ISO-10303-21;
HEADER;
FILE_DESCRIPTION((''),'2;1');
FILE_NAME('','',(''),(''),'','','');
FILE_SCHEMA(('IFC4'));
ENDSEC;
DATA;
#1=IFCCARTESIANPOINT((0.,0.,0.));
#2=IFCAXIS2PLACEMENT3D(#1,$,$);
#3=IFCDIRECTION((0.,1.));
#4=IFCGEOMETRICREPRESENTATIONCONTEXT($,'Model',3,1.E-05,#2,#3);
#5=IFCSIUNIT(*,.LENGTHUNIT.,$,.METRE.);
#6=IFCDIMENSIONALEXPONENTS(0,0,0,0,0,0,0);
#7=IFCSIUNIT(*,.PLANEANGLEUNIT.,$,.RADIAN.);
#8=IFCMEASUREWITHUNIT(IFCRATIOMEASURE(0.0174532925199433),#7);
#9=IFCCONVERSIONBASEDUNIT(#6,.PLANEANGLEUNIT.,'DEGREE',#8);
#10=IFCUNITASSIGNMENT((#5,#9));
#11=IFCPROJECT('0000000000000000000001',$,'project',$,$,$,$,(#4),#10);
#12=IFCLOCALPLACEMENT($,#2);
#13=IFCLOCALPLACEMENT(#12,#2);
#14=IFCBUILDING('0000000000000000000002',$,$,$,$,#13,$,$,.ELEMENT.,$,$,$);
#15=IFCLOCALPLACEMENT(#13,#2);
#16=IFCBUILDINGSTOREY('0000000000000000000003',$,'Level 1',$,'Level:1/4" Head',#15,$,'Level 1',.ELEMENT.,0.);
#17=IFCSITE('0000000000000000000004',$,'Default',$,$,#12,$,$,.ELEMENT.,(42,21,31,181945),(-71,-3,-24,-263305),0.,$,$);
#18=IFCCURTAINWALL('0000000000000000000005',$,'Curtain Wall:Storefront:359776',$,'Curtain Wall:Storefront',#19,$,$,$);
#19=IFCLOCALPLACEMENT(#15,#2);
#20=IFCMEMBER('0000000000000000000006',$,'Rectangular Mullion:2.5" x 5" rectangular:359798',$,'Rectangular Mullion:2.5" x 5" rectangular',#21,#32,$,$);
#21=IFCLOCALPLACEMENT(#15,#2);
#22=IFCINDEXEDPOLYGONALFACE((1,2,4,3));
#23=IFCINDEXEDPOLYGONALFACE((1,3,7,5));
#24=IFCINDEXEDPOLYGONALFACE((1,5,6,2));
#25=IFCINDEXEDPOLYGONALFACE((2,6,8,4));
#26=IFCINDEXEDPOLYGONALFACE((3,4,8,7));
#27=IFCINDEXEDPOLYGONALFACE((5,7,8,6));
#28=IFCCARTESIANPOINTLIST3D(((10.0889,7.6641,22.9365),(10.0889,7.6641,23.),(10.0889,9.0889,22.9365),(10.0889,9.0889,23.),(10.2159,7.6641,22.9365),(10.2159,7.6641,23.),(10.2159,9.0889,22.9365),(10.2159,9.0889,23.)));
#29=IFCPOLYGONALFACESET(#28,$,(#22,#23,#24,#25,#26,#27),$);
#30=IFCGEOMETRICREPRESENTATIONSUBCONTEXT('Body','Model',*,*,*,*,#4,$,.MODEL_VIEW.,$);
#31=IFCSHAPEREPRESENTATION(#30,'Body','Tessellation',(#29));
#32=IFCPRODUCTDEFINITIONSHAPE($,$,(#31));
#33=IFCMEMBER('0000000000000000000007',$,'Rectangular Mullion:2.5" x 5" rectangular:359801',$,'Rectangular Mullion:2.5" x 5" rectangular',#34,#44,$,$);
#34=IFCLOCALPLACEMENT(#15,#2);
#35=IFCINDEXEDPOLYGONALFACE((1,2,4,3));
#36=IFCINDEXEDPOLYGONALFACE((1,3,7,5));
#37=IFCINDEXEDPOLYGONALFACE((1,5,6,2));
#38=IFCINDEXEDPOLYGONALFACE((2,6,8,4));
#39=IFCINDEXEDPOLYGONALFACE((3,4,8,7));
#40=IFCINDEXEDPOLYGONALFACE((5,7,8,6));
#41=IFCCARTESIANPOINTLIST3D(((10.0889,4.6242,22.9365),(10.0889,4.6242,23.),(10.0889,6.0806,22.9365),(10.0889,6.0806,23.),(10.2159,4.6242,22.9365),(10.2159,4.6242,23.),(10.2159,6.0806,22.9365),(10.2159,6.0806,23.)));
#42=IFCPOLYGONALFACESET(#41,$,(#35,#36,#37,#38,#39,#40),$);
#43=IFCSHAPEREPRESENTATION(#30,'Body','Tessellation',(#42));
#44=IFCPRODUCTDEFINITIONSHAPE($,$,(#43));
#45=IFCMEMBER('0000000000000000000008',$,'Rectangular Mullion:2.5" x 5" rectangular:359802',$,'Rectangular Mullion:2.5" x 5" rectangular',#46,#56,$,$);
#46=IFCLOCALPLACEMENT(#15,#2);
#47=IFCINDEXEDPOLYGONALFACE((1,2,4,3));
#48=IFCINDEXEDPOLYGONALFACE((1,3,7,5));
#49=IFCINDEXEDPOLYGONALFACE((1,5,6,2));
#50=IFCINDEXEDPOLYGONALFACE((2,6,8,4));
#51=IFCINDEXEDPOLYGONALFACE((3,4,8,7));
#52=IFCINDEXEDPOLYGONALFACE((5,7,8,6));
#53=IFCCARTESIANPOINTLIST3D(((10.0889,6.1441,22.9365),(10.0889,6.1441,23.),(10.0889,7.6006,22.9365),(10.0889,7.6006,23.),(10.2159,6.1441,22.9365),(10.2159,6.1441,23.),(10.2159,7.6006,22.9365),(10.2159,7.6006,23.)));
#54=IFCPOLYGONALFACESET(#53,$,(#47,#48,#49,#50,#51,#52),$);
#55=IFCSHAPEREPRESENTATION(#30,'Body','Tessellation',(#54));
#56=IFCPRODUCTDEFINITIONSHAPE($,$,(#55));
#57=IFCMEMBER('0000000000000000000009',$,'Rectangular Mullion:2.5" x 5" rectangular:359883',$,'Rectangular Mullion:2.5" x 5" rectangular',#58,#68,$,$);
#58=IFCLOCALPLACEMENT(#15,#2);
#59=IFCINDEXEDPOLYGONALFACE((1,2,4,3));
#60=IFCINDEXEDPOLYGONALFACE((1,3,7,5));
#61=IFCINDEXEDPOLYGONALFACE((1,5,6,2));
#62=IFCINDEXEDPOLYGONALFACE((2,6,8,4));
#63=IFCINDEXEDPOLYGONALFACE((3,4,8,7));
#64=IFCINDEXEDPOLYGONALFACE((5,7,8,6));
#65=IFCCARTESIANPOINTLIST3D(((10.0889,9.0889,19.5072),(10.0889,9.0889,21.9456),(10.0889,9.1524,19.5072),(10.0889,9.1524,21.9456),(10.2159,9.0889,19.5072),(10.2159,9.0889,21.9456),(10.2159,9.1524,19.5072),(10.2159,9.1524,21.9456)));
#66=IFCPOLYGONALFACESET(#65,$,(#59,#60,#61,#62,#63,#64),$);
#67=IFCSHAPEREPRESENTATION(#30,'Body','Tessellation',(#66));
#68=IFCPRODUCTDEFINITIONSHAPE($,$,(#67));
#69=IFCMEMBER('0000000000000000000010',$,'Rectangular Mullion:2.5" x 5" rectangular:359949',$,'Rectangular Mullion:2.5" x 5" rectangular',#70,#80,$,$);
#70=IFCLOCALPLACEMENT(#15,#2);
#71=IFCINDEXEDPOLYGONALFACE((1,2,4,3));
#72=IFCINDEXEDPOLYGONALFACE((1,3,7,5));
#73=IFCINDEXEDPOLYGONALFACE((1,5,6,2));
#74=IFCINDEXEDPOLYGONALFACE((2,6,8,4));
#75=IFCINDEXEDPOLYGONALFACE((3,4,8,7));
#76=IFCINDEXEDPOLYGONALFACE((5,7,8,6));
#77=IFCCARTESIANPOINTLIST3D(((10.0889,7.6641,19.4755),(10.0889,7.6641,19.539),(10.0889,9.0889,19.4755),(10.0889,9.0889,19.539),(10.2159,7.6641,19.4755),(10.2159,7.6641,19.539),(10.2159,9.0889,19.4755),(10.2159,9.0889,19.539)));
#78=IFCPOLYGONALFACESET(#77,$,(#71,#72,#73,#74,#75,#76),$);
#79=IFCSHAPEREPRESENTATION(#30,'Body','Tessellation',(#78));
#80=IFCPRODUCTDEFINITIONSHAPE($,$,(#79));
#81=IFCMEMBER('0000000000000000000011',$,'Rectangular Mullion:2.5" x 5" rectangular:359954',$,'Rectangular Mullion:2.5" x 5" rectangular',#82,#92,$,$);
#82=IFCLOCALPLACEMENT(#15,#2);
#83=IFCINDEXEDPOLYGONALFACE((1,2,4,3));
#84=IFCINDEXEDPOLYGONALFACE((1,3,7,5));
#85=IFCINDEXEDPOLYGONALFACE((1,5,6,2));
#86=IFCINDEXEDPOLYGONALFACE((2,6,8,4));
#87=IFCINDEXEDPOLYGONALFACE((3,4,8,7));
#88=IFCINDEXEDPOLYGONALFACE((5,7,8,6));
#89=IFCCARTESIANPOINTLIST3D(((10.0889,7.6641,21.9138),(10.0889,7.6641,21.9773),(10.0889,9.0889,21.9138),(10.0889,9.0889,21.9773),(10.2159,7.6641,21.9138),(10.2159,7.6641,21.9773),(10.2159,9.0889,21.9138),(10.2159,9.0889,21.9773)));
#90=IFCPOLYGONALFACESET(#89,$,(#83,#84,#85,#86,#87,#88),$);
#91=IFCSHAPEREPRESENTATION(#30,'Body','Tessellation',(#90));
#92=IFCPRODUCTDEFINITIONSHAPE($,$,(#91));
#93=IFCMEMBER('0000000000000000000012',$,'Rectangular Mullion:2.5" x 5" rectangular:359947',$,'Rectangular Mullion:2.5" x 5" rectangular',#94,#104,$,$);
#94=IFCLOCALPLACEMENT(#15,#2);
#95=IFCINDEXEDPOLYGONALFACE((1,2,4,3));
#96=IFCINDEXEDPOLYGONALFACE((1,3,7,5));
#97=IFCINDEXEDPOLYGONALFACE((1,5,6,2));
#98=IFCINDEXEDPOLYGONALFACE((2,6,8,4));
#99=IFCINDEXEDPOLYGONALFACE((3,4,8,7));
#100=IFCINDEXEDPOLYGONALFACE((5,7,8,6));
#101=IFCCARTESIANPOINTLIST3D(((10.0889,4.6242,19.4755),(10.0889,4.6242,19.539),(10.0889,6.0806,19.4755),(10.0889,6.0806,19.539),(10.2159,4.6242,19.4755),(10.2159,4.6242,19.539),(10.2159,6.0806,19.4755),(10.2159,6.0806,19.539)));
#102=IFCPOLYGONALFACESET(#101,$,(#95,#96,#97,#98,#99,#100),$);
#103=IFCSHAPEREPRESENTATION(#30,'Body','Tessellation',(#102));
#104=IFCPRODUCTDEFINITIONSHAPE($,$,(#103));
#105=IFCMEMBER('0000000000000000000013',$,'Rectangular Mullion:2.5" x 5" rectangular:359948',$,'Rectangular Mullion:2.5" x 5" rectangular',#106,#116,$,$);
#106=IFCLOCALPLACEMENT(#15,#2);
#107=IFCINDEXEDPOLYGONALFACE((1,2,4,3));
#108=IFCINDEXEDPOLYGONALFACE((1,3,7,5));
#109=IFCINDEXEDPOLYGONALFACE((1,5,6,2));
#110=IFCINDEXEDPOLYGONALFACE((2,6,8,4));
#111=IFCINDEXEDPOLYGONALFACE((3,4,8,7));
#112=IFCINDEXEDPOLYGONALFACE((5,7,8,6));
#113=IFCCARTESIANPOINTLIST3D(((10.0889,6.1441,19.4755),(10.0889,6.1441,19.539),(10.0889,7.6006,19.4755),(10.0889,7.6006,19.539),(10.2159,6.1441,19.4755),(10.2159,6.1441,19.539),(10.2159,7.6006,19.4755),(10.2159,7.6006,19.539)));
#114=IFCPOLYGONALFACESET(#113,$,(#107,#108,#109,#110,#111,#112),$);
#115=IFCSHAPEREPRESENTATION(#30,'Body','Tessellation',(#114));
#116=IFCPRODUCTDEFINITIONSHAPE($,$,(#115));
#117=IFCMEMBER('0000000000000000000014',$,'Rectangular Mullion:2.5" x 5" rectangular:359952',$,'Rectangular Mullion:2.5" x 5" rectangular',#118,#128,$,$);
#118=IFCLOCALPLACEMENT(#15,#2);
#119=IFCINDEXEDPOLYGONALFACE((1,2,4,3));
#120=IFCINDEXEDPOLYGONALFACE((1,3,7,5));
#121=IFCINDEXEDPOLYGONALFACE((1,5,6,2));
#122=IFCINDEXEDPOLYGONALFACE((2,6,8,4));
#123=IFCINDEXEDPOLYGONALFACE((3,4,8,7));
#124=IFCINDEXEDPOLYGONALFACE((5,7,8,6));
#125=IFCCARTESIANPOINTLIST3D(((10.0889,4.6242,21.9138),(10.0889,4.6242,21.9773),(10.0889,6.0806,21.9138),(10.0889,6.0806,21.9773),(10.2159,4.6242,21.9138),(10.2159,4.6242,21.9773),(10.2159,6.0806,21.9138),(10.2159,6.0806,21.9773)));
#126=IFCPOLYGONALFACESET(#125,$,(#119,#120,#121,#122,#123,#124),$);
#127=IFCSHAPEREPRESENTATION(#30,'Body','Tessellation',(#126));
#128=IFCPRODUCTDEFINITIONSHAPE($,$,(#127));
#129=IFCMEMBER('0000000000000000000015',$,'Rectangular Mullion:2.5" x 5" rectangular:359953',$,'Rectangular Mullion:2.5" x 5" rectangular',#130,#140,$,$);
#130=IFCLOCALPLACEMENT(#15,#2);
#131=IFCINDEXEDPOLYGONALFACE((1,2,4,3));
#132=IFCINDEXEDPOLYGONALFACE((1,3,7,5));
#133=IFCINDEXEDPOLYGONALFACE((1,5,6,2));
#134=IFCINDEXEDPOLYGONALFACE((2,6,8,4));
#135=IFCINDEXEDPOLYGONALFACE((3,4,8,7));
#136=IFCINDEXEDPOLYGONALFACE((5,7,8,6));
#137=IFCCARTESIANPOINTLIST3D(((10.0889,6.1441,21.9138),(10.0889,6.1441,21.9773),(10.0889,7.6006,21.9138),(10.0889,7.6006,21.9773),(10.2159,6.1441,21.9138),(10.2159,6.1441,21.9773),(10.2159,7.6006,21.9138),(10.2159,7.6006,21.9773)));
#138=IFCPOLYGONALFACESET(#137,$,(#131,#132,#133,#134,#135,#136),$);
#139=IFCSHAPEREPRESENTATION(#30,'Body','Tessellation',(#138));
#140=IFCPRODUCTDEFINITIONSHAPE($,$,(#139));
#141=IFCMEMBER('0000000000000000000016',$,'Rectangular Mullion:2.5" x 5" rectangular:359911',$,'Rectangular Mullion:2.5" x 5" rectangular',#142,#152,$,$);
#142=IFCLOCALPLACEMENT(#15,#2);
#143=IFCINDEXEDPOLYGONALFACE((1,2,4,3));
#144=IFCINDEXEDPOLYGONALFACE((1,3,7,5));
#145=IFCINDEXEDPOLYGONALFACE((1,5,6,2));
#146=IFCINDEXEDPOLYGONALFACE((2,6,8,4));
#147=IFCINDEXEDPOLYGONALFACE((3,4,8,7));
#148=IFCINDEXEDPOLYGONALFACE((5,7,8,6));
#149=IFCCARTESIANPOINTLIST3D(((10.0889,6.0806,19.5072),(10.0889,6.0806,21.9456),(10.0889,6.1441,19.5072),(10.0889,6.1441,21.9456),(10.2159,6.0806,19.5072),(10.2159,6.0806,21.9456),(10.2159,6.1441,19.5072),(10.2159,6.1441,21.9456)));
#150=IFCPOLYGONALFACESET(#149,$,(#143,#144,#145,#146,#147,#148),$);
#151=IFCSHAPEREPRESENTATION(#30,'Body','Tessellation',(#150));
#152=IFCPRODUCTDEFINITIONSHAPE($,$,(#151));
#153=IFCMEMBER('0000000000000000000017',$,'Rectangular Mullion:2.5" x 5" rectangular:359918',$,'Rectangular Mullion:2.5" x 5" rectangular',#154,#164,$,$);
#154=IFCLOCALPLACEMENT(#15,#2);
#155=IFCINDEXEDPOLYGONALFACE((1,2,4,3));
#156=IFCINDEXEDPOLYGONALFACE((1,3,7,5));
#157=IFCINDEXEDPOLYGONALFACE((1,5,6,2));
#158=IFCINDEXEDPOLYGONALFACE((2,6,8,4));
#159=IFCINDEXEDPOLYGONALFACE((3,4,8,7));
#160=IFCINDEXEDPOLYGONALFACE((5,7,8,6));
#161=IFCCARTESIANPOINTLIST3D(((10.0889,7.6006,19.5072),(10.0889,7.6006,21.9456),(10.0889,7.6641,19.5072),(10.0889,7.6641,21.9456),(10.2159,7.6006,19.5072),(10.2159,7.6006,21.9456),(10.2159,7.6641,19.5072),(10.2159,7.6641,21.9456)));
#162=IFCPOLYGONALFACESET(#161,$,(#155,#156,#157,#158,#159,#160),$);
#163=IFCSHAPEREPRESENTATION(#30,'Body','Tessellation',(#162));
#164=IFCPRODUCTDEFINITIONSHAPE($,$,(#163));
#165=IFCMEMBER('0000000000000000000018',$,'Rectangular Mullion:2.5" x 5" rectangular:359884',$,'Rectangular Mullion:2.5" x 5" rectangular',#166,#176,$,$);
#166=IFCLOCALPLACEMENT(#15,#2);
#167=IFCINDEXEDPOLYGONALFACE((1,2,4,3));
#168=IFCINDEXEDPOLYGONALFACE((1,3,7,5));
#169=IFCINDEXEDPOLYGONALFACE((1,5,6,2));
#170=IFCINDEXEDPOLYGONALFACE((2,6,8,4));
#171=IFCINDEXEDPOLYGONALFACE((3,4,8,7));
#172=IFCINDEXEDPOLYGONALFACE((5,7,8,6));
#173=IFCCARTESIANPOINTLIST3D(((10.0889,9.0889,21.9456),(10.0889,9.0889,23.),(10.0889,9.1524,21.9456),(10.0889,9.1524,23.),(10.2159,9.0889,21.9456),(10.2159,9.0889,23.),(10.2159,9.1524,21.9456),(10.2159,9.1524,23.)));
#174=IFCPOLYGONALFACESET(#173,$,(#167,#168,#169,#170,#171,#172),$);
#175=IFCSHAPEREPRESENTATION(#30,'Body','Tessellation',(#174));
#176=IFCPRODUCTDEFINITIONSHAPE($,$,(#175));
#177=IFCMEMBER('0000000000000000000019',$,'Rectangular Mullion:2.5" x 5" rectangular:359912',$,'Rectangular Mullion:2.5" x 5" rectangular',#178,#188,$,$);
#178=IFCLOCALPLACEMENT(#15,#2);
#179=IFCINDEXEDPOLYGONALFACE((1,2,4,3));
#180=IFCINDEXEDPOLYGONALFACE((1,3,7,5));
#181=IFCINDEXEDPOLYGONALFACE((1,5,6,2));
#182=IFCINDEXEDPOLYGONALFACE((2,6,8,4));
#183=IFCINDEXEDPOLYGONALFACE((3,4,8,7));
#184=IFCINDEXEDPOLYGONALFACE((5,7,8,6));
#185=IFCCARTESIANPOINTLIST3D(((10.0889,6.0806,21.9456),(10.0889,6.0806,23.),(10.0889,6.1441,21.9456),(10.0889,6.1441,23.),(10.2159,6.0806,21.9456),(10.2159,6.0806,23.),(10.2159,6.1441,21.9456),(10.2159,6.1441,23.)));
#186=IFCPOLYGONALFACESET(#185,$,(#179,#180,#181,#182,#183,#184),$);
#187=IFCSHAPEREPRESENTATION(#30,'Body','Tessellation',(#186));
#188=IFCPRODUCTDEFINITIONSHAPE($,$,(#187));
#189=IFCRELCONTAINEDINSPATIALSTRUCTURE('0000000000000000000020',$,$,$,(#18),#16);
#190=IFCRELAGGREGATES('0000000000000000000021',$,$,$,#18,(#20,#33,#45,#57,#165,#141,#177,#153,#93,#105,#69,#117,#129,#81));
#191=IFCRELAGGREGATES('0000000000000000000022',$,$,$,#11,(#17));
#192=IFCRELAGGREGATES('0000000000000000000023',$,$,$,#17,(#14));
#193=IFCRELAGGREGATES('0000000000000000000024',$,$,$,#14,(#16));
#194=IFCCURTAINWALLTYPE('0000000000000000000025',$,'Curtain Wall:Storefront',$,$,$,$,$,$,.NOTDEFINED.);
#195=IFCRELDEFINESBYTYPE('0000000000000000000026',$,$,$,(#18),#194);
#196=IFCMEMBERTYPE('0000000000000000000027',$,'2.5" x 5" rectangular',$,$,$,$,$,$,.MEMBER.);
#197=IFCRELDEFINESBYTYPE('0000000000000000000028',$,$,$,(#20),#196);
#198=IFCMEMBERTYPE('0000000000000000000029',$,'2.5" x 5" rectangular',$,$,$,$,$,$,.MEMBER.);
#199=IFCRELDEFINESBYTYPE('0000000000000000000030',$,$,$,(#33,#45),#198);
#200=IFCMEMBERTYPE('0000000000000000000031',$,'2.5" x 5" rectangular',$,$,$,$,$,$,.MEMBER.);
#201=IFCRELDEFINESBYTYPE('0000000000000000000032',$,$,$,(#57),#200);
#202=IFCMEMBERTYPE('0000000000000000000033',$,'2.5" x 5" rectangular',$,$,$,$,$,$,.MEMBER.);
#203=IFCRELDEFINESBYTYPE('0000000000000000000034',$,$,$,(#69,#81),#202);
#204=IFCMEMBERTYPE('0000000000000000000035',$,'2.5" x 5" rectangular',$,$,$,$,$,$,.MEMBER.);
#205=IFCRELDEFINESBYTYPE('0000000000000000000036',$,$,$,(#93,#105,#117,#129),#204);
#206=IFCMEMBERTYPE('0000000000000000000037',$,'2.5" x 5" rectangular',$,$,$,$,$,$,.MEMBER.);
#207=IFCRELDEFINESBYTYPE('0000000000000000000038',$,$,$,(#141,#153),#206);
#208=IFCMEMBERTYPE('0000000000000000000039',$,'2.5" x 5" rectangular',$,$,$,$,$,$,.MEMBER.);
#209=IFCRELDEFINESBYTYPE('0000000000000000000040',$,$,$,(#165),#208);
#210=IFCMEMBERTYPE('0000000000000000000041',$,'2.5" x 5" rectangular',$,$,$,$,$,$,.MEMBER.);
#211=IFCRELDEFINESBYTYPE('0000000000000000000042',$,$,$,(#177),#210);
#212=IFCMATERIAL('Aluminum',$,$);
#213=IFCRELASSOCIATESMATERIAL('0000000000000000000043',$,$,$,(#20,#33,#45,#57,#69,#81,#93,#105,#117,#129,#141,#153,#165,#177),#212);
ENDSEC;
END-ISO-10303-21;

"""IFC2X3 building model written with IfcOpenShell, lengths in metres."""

from ifc_helpers import new_model, entity, si_unit, converted_unit, direction, frame, origin, origin_2d_with_axis, place, context, subcontext, project, spatial, rectangle, extrude, source, transform, mapped, material, type_object, type_shapes, element, aggregate, save


model = new_model("IFC2X3")

# Units and contexts
model_context = context("Model", 3, precision=1e-05, world=origin(), true_north=direction((0.0, 1.0)))
body_context = subcontext(model_context, "Body", "Model", "MODEL_VIEW")
ifc_project = project(units=[si_unit("LENGTHUNIT", "METRE"), converted_unit("PLANEANGLEUNIT", "DEGREE", entity("IfcRatioMeasure", 0.0174532925199433), si_unit("PLANEANGLEUNIT", "RADIAN"), dimensions=[0, 0, 0, 0, 0, 0, 0])], contexts=[model_context])

# Site, building, storey
site_placement = place(None, origin())
site = spatial("IfcSite", under=ifc_project, at=site_placement, Name="Default", CompositionType="ELEMENT", RefLatitude=(42, 21, 31, 181945), RefLongitude=(-71, -3, -24, -263305), RefElevation=0.0)
building_placement = place(site_placement, origin())
building = spatial("IfcBuilding", under=site, at=building_placement, CompositionType="ELEMENT")
storey_placement = place(building_placement, origin())
storey = spatial("IfcBuildingStorey", under=building, at=storey_placement, Name="Level 1", ObjectType="Level:1/4\" Head", LongName="Level 1", CompositionType="ELEMENT", Elevation=0.0)

# Curtain wall, members
curtain_wall_type = type_object("IfcCurtainWallType", Name="Curtain Wall:Storefront", PredefinedType="NOTDEFINED")
curtain_wall_placement = place(storey_placement, origin())
curtain_wall = element("IfcCurtainWall", 1, at=curtain_wall_placement, inside=storey, type_object=curtain_wall_type, Name="Curtain Wall:Storefront:359776", ObjectType="Curtain Wall:Storefront")
ifc_material_1 = material(Name="Aluminum")
member_type_1 = type_object("IfcMemberType", Name="2.5\" x 5\" rectangular", PredefinedType="MEMBER")
shared_shape_1 = source(origin(), body_context, "Body", "SweptSolid", [
    extrude(rectangle(XDim=0.127, YDim=0.0635, at=origin_2d_with_axis()), frame((-0.0318, 0.0, -1.4248), z_axis=(0.0, 0.0, 1.0), x_axis=(0.0, -1.0, 0.0)), (0.0, 0.0, 1.0), 1.4248),
])
type_shapes(member_type_1, [shared_shape_1])
member_1_placement = place(storey_placement, frame((10.1524, 9.0889, 23.0), z_axis=(0.0, 1.0, 0.0), x_axis=(0.0, 0.0, 1.0)))
member_1 = element("IfcMember", 2, at=member_1_placement, type_object=member_type_1, material=ifc_material_1, Name="Rectangular Mullion:2.5\" x 5\" rectangular:359798", ObjectType="Rectangular Mullion:2.5\" x 5\" rectangular", context=body_context, shape_type="MappedRepresentation", body=[
    mapped(shared_shape_1, transform((0.0, 0.0, 0.0), scale=1.0)),
])
member_type_2 = type_object("IfcMemberType", Name="2.5\" x 5\" rectangular", PredefinedType="MEMBER")
shared_shape_2 = source(origin(), body_context, "Body", "SweptSolid", [
    extrude(rectangle(XDim=0.127, YDim=0.0635, at=origin_2d_with_axis()), frame((-0.0318, 0.0, -1.4565), z_axis=(0.0, 0.0, 1.0), x_axis=(0.0, -1.0, 0.0)), (0.0, 0.0, 1.0), 1.4565),
])
type_shapes(member_type_2, [shared_shape_2])
member_2_placement = place(storey_placement, frame((10.1524, 6.0806, 23.0), z_axis=(0.0, 1.0, 0.0), x_axis=(0.0, 0.0, 1.0)))
member_2 = element("IfcMember", 3, at=member_2_placement, type_object=member_type_2, material=ifc_material_1, Name="Rectangular Mullion:2.5\" x 5\" rectangular:359801", ObjectType="Rectangular Mullion:2.5\" x 5\" rectangular", context=body_context, shape_type="MappedRepresentation", body=[
    mapped(shared_shape_2, transform((0.0, 0.0, 0.0), scale=1.0)),
])
member_3_placement = place(storey_placement, frame((10.1524, 7.6006, 23.0), z_axis=(0.0, 1.0, 0.0), x_axis=(0.0, 0.0, 1.0)))
member_3 = element("IfcMember", 4, at=member_3_placement, type_object=member_type_2, material=ifc_material_1, Name="Rectangular Mullion:2.5\" x 5\" rectangular:359802", ObjectType="Rectangular Mullion:2.5\" x 5\" rectangular", context=body_context, shape_type="MappedRepresentation", body=[
    mapped(shared_shape_2, transform((0.0, 0.0, 0.0), scale=1.0)),
])
member_type_3 = type_object("IfcMemberType", Name="2.5\" x 5\" rectangular", PredefinedType="MEMBER")
shared_shape_3 = source(origin(), body_context, "Body", "SweptSolid", [
    extrude(rectangle(XDim=0.127, YDim=0.0635, at=origin_2d_with_axis()), frame((-0.0318, 0.0, -2.4384), z_axis=(0.0, 0.0, 1.0), x_axis=(0.0, -1.0, 0.0)), (0.0, 0.0, 1.0), 2.4384),
])
type_shapes(member_type_3, [shared_shape_3])
member_4_placement = place(storey_placement, frame((10.1524, 9.1524, 19.5072), z_axis=(0.0, 0.0, -1.0), x_axis=(0.0, 1.0, 0.0)))
member_4 = element("IfcMember", 5, at=member_4_placement, type_object=member_type_3, material=ifc_material_1, Name="Rectangular Mullion:2.5\" x 5\" rectangular:359883", ObjectType="Rectangular Mullion:2.5\" x 5\" rectangular", context=body_context, shape_type="MappedRepresentation", body=[
    mapped(shared_shape_3, transform((0.0, 0.0, 0.0), scale=1.0)),
])
member_type_4 = type_object("IfcMemberType", Name="2.5\" x 5\" rectangular", PredefinedType="MEMBER")
shared_shape_4 = source(origin(), body_context, "Body", "SweptSolid", [
    extrude(rectangle(XDim=0.127, YDim=0.0635, at=origin_2d_with_axis()), frame((0.0, 0.0, -1.4248), z_axis=(0.0, 0.0, 1.0), x_axis=(0.0, -1.0, 0.0)), (0.0, 0.0, 1.0), 1.4248),
])
type_shapes(member_type_4, [shared_shape_4])
member_5_placement = place(storey_placement, frame((10.1524, 9.0889, 19.5072), z_axis=(0.0, 1.0, 0.0), x_axis=(0.0, 0.0, 1.0)))
member_5 = element("IfcMember", 6, at=member_5_placement, type_object=member_type_4, material=ifc_material_1, Name="Rectangular Mullion:2.5\" x 5\" rectangular:359949", ObjectType="Rectangular Mullion:2.5\" x 5\" rectangular", context=body_context, shape_type="MappedRepresentation", body=[
    mapped(shared_shape_4, transform((0.0, 0.0, 0.0), scale=1.0)),
])
member_6_placement = place(storey_placement, frame((10.1524, 9.0889, 21.9456), z_axis=(0.0, 1.0, 0.0), x_axis=(0.0, 0.0, 1.0)))
member_6 = element("IfcMember", 7, at=member_6_placement, type_object=member_type_4, material=ifc_material_1, Name="Rectangular Mullion:2.5\" x 5\" rectangular:359954", ObjectType="Rectangular Mullion:2.5\" x 5\" rectangular", context=body_context, shape_type="MappedRepresentation", body=[
    mapped(shared_shape_4, transform((0.0, 0.0, 0.0), scale=1.0)),
])
member_type_5 = type_object("IfcMemberType", Name="2.5\" x 5\" rectangular", PredefinedType="MEMBER")
shared_shape_5 = source(origin(), body_context, "Body", "SweptSolid", [
    extrude(rectangle(XDim=0.127, YDim=0.0635, at=origin_2d_with_axis()), frame((0.0, 0.0, -1.4565), z_axis=(0.0, 0.0, 1.0), x_axis=(0.0, -1.0, 0.0)), (0.0, 0.0, 1.0), 1.4565),
])
type_shapes(member_type_5, [shared_shape_5])
member_7_placement = place(storey_placement, frame((10.1524, 6.0806, 19.5072), z_axis=(0.0, 1.0, 0.0), x_axis=(0.0, 0.0, 1.0)))
member_7 = element("IfcMember", 8, at=member_7_placement, type_object=member_type_5, material=ifc_material_1, Name="Rectangular Mullion:2.5\" x 5\" rectangular:359947", ObjectType="Rectangular Mullion:2.5\" x 5\" rectangular", context=body_context, shape_type="MappedRepresentation", body=[
    mapped(shared_shape_5, transform((0.0, 0.0, 0.0), scale=1.0)),
])
member_8_placement = place(storey_placement, frame((10.1524, 7.6006, 19.5072), z_axis=(0.0, 1.0, 0.0), x_axis=(0.0, 0.0, 1.0)))
member_8 = element("IfcMember", 9, at=member_8_placement, type_object=member_type_5, material=ifc_material_1, Name="Rectangular Mullion:2.5\" x 5\" rectangular:359948", ObjectType="Rectangular Mullion:2.5\" x 5\" rectangular", context=body_context, shape_type="MappedRepresentation", body=[
    mapped(shared_shape_5, transform((0.0, 0.0, 0.0), scale=1.0)),
])
member_9_placement = place(storey_placement, frame((10.1524, 6.0806, 21.9456), z_axis=(0.0, 1.0, 0.0), x_axis=(0.0, 0.0, 1.0)))
member_9 = element("IfcMember", 10, at=member_9_placement, type_object=member_type_5, material=ifc_material_1, Name="Rectangular Mullion:2.5\" x 5\" rectangular:359952", ObjectType="Rectangular Mullion:2.5\" x 5\" rectangular", context=body_context, shape_type="MappedRepresentation", body=[
    mapped(shared_shape_5, transform((0.0, 0.0, 0.0), scale=1.0)),
])
member_10_placement = place(storey_placement, frame((10.1524, 7.6006, 21.9456), z_axis=(0.0, 1.0, 0.0), x_axis=(0.0, 0.0, 1.0)))
member_10 = element("IfcMember", 11, at=member_10_placement, type_object=member_type_5, material=ifc_material_1, Name="Rectangular Mullion:2.5\" x 5\" rectangular:359953", ObjectType="Rectangular Mullion:2.5\" x 5\" rectangular", context=body_context, shape_type="MappedRepresentation", body=[
    mapped(shared_shape_5, transform((0.0, 0.0, 0.0), scale=1.0)),
])
member_type_6 = type_object("IfcMemberType", Name="2.5\" x 5\" rectangular", PredefinedType="MEMBER")
shared_shape_6 = source(origin(), body_context, "Body", "SweptSolid", [
    extrude(rectangle(XDim=0.127, YDim=0.0635, at=origin_2d_with_axis()), frame((0.0, 0.0, -2.4384), z_axis=(0.0, 0.0, 1.0), x_axis=(0.0, -1.0, 0.0)), (0.0, 0.0, 1.0), 2.4384),
])
type_shapes(member_type_6, [shared_shape_6])
member_11_placement = place(storey_placement, frame((10.1524, 6.1124, 19.5072), z_axis=(0.0, 0.0, -1.0), x_axis=(0.0, 1.0, 0.0)))
member_11 = element("IfcMember", 12, at=member_11_placement, type_object=member_type_6, material=ifc_material_1, Name="Rectangular Mullion:2.5\" x 5\" rectangular:359911", ObjectType="Rectangular Mullion:2.5\" x 5\" rectangular", context=body_context, shape_type="MappedRepresentation", body=[
    mapped(shared_shape_6, transform((0.0, 0.0, 0.0), scale=1.0)),
])
member_12_placement = place(storey_placement, frame((10.1524, 7.6324, 19.5072), z_axis=(0.0, 0.0, -1.0), x_axis=(0.0, 1.0, 0.0)))
member_12 = element("IfcMember", 13, at=member_12_placement, type_object=member_type_6, material=ifc_material_1, Name="Rectangular Mullion:2.5\" x 5\" rectangular:359918", ObjectType="Rectangular Mullion:2.5\" x 5\" rectangular", context=body_context, shape_type="MappedRepresentation", body=[
    mapped(shared_shape_6, transform((0.0, 0.0, 0.0), scale=1.0)),
])
member_type_7 = type_object("IfcMemberType", Name="2.5\" x 5\" rectangular", PredefinedType="MEMBER")
shared_shape_7 = source(origin(), body_context, "Body", "SweptSolid", [
    extrude(rectangle(XDim=0.127, YDim=0.0635, at=origin_2d_with_axis()), frame((-0.0318, 0.0, -1.0544), z_axis=(0.0, 0.0, 1.0), x_axis=(0.0, -1.0, 0.0)), (0.0, 0.0, 1.0), 1.0544),
])
type_shapes(member_type_7, [shared_shape_7])
member_13_placement = place(storey_placement, frame((10.1524, 9.1524, 21.9456), z_axis=(0.0, 0.0, -1.0), x_axis=(0.0, 1.0, 0.0)))
member_13 = element("IfcMember", 14, at=member_13_placement, type_object=member_type_7, material=ifc_material_1, Name="Rectangular Mullion:2.5\" x 5\" rectangular:359884", ObjectType="Rectangular Mullion:2.5\" x 5\" rectangular", context=body_context, shape_type="MappedRepresentation", body=[
    mapped(shared_shape_7, transform((0.0, 0.0, 0.0), scale=1.0)),
])
member_type_8 = type_object("IfcMemberType", Name="2.5\" x 5\" rectangular", PredefinedType="MEMBER")
shared_shape_8 = source(origin(), body_context, "Body", "SweptSolid", [
    extrude(rectangle(XDim=0.127, YDim=0.0635, at=origin_2d_with_axis()), frame((0.0, 0.0, -1.0544), z_axis=(0.0, 0.0, 1.0), x_axis=(0.0, -1.0, 0.0)), (0.0, 0.0, 1.0), 1.0544),
])
type_shapes(member_type_8, [shared_shape_8])
member_14_placement = place(storey_placement, frame((10.1524, 6.1124, 21.9456), z_axis=(0.0, 0.0, -1.0), x_axis=(0.0, 1.0, 0.0)))
member_14 = element("IfcMember", 15, at=member_14_placement, type_object=member_type_8, material=ifc_material_1, Name="Rectangular Mullion:2.5\" x 5\" rectangular:359912", ObjectType="Rectangular Mullion:2.5\" x 5\" rectangular", context=body_context, shape_type="MappedRepresentation", body=[
    mapped(shared_shape_8, transform((0.0, 0.0, 0.0), scale=1.0)),
])
aggregate(curtain_wall, [member_1, member_2, member_3, member_4, member_13, member_11, member_14, member_12, member_7, member_8, member_5, member_9, member_10, member_6])

save(model, "model.ifc")
